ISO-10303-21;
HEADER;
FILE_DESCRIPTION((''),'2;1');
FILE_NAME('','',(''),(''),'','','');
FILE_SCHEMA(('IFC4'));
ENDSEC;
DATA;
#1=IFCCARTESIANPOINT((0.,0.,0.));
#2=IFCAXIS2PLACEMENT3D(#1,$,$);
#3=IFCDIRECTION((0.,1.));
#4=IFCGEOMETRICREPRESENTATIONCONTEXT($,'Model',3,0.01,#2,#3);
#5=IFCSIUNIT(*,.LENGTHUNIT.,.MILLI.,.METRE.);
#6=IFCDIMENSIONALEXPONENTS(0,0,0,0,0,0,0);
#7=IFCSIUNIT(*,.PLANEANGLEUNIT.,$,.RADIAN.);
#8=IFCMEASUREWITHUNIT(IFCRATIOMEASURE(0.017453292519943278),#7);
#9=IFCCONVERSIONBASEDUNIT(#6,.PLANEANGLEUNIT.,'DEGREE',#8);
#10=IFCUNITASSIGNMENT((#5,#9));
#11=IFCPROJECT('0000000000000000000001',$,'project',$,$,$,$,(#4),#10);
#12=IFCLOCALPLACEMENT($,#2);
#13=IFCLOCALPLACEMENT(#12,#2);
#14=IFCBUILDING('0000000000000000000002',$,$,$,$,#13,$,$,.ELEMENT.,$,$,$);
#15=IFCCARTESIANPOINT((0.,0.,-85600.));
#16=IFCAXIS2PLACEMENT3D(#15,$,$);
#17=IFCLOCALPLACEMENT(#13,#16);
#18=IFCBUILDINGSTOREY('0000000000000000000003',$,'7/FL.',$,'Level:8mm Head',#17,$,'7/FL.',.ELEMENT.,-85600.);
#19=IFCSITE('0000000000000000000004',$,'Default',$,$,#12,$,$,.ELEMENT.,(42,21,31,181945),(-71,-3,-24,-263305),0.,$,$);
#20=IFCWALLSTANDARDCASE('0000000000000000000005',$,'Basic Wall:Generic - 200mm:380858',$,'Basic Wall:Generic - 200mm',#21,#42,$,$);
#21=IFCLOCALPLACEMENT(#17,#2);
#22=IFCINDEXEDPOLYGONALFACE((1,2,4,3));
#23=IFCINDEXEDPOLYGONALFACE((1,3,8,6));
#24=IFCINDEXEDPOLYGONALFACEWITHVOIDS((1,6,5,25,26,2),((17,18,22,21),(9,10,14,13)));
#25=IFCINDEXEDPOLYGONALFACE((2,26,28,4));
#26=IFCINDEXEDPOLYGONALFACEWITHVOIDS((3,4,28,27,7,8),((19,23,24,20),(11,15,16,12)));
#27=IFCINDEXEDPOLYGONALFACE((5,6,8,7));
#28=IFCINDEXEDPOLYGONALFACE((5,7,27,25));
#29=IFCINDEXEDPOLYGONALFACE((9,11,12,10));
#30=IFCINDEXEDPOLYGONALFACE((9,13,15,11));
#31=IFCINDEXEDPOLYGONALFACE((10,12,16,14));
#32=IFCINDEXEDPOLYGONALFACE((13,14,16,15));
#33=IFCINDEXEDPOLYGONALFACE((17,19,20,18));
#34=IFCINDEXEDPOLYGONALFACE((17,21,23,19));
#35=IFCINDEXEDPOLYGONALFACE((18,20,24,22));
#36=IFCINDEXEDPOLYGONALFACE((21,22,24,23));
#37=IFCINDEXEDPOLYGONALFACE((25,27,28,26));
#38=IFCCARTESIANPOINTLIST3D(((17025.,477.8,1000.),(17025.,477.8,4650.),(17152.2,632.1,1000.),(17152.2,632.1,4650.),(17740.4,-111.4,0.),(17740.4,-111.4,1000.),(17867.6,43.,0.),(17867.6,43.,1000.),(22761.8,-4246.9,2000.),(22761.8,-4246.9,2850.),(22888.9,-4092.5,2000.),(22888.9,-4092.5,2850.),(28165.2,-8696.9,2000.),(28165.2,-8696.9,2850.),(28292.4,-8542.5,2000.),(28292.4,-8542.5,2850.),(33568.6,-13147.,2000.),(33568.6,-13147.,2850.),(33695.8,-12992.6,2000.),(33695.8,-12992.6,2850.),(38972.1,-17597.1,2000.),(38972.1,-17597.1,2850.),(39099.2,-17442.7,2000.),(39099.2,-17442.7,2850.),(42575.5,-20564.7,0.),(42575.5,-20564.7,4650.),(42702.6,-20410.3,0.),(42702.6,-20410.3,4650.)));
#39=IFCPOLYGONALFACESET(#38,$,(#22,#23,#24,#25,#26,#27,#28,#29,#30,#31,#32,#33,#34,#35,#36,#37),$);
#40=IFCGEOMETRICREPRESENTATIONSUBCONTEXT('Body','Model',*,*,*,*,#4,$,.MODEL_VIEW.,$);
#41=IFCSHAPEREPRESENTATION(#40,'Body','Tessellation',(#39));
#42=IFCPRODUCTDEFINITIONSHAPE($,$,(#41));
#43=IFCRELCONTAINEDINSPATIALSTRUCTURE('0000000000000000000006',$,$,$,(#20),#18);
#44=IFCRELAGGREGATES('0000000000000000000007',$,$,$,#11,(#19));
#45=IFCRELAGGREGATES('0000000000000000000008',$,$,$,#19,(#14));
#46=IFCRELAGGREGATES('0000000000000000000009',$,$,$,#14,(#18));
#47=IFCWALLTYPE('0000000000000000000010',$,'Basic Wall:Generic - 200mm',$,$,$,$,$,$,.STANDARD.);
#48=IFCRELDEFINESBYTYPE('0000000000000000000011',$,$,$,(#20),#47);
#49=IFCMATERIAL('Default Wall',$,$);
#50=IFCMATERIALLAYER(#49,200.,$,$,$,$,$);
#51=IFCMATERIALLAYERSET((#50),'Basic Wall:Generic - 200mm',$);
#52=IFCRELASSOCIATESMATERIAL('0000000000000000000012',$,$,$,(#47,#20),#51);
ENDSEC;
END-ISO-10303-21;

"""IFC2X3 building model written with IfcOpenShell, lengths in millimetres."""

from ifc_helpers import new_model, entity, si_unit, converted_unit, direction, frame, frame_2d, origin, place, context, subcontext, project, spatial, rectangle, extrude, material, layer, layer_set, layer_usage, type_object, element, save


model = new_model("IFC2X3")

# Units and contexts
model_context = context("Model", 3, precision=0.01, world=origin(), true_north=direction((0.0, 1.0)))
body_context = subcontext(model_context, "Body", "Model", "MODEL_VIEW")
ifc_project = project(units=[si_unit("LENGTHUNIT", "METRE", prefix="MILLI"), converted_unit("PLANEANGLEUNIT", "DEGREE", entity("IfcRatioMeasure", 0.017453292519943278), si_unit("PLANEANGLEUNIT", "RADIAN"), dimensions=[0, 0, 0, 0, 0, 0, 0])], contexts=[model_context])

# Site, building, storey
site_placement = place(None, origin())
site = spatial("IfcSite", under=ifc_project, at=site_placement, Name="Default", CompositionType="ELEMENT", RefLatitude=(42, 21, 31, 181945), RefLongitude=(-71, -3, -24, -263305), RefElevation=0.0)
building_placement = place(site_placement, origin())
building = spatial("IfcBuilding", under=site, at=building_placement, CompositionType="ELEMENT")
storey_placement = place(building_placement, frame((0.0, 0.0, -85600.0)))
storey = spatial("IfcBuildingStorey", under=building, at=storey_placement, Name="7/FL.", ObjectType="Level:8mm Head", LongName="7/FL.", CompositionType="ELEMENT", Elevation=-85600.0)

# Wall, openings
ifc_material_1 = material(Name="Default Wall")
ifc_layer = layer(ifc_material_1, 200.0)
ifc_layer_set = layer_set([ifc_layer], Name="Basic Wall:Generic - 200mm")
ifc_layer_usage = layer_usage(ifc_layer_set, "AXIS2", "NEGATIVE", 100.0)
wall_type = type_object("IfcWallType", Name="Basic Wall:Generic - 200mm", PredefinedType="STANDARD", material=ifc_layer_set)
wall_1_placement = place(storey_placement, frame((42639.0, -20487.5, 0.0), z_axis=(0.0, 0.0, 1.0), x_axis=(-0.771917, 0.635723, 0.0)))
wall_1 = element("IfcWallStandardCase", 1, at=wall_1_placement, inside=storey, type_object=wall_type, material=ifc_layer_usage, Name="Basic Wall:Generic - 200mm:380858", ObjectType="Basic Wall:Generic - 200mm", context=body_context, shape_type="SweptSolid", body=[
    extrude(rectangle(XDim=33100.0, YDim=200.0, at=frame_2d((16550.0, 0.0), x_axis=(-1.0, 0.0))), origin(), (0.0, 0.0, 1.0), 4650.0),
])
opening_1_placement = place(wall_1_placement, origin())
element("IfcOpeningElement", 2, at=opening_1_placement, cuts=wall_1, ObjectType="Opening", context=body_context, shape_type="SweptSolid", body=[
    extrude(rectangle(XDim=850.0, YDim=7000.0, at=frame_2d((0.0, 0.0), x_axis=(1.0, 0.0))), frame((8168.1, -100.0, 2425.0), z_axis=(0.0, 1.0, 0.0), x_axis=(0.0, 0.0, -1.0)), (0.0, 0.0, 1.0), 200.0),
])
opening_2_placement = place(wall_1_placement, origin())
element("IfcOpeningElement", 3, at=opening_2_placement, cuts=wall_1, ObjectType="Opening", context=body_context, shape_type="SweptSolid", body=[
    extrude(rectangle(XDim=850.0, YDim=7000.0, at=frame_2d((0.0, 0.0), x_axis=(1.0, 0.0))), frame((22168.1, -100.0, 2425.0), z_axis=(0.0, 1.0, 0.0), x_axis=(0.0, 0.0, -1.0)), (0.0, 0.0, 1.0), 200.0),
])
opening_3_placement = place(wall_1_placement, frame((45938.2, 11292.0, 0.0), z_axis=(0.0, 0.0, 1.0), x_axis=(-0.771917, -0.635723, 0.0)))
element("IfcOpeningElement", 4, at=opening_3_placement, cuts=wall_1, ObjectType="Opening", context=body_context, shape_type="SweptSolid", body=[
    extrude(rectangle(XDim=1000.0, YDim=1010.1, at=frame_2d((0.0, 0.0), x_axis=(1.0, 0.0))), frame((17485.8, 373.8, 500.0), z_axis=(-0.635723, -0.771917, 0.0), x_axis=(0.0, 0.0, -1.0)), (0.0, 0.0, 1.0), 1012.7),
])

save(model, "model.ifc")
